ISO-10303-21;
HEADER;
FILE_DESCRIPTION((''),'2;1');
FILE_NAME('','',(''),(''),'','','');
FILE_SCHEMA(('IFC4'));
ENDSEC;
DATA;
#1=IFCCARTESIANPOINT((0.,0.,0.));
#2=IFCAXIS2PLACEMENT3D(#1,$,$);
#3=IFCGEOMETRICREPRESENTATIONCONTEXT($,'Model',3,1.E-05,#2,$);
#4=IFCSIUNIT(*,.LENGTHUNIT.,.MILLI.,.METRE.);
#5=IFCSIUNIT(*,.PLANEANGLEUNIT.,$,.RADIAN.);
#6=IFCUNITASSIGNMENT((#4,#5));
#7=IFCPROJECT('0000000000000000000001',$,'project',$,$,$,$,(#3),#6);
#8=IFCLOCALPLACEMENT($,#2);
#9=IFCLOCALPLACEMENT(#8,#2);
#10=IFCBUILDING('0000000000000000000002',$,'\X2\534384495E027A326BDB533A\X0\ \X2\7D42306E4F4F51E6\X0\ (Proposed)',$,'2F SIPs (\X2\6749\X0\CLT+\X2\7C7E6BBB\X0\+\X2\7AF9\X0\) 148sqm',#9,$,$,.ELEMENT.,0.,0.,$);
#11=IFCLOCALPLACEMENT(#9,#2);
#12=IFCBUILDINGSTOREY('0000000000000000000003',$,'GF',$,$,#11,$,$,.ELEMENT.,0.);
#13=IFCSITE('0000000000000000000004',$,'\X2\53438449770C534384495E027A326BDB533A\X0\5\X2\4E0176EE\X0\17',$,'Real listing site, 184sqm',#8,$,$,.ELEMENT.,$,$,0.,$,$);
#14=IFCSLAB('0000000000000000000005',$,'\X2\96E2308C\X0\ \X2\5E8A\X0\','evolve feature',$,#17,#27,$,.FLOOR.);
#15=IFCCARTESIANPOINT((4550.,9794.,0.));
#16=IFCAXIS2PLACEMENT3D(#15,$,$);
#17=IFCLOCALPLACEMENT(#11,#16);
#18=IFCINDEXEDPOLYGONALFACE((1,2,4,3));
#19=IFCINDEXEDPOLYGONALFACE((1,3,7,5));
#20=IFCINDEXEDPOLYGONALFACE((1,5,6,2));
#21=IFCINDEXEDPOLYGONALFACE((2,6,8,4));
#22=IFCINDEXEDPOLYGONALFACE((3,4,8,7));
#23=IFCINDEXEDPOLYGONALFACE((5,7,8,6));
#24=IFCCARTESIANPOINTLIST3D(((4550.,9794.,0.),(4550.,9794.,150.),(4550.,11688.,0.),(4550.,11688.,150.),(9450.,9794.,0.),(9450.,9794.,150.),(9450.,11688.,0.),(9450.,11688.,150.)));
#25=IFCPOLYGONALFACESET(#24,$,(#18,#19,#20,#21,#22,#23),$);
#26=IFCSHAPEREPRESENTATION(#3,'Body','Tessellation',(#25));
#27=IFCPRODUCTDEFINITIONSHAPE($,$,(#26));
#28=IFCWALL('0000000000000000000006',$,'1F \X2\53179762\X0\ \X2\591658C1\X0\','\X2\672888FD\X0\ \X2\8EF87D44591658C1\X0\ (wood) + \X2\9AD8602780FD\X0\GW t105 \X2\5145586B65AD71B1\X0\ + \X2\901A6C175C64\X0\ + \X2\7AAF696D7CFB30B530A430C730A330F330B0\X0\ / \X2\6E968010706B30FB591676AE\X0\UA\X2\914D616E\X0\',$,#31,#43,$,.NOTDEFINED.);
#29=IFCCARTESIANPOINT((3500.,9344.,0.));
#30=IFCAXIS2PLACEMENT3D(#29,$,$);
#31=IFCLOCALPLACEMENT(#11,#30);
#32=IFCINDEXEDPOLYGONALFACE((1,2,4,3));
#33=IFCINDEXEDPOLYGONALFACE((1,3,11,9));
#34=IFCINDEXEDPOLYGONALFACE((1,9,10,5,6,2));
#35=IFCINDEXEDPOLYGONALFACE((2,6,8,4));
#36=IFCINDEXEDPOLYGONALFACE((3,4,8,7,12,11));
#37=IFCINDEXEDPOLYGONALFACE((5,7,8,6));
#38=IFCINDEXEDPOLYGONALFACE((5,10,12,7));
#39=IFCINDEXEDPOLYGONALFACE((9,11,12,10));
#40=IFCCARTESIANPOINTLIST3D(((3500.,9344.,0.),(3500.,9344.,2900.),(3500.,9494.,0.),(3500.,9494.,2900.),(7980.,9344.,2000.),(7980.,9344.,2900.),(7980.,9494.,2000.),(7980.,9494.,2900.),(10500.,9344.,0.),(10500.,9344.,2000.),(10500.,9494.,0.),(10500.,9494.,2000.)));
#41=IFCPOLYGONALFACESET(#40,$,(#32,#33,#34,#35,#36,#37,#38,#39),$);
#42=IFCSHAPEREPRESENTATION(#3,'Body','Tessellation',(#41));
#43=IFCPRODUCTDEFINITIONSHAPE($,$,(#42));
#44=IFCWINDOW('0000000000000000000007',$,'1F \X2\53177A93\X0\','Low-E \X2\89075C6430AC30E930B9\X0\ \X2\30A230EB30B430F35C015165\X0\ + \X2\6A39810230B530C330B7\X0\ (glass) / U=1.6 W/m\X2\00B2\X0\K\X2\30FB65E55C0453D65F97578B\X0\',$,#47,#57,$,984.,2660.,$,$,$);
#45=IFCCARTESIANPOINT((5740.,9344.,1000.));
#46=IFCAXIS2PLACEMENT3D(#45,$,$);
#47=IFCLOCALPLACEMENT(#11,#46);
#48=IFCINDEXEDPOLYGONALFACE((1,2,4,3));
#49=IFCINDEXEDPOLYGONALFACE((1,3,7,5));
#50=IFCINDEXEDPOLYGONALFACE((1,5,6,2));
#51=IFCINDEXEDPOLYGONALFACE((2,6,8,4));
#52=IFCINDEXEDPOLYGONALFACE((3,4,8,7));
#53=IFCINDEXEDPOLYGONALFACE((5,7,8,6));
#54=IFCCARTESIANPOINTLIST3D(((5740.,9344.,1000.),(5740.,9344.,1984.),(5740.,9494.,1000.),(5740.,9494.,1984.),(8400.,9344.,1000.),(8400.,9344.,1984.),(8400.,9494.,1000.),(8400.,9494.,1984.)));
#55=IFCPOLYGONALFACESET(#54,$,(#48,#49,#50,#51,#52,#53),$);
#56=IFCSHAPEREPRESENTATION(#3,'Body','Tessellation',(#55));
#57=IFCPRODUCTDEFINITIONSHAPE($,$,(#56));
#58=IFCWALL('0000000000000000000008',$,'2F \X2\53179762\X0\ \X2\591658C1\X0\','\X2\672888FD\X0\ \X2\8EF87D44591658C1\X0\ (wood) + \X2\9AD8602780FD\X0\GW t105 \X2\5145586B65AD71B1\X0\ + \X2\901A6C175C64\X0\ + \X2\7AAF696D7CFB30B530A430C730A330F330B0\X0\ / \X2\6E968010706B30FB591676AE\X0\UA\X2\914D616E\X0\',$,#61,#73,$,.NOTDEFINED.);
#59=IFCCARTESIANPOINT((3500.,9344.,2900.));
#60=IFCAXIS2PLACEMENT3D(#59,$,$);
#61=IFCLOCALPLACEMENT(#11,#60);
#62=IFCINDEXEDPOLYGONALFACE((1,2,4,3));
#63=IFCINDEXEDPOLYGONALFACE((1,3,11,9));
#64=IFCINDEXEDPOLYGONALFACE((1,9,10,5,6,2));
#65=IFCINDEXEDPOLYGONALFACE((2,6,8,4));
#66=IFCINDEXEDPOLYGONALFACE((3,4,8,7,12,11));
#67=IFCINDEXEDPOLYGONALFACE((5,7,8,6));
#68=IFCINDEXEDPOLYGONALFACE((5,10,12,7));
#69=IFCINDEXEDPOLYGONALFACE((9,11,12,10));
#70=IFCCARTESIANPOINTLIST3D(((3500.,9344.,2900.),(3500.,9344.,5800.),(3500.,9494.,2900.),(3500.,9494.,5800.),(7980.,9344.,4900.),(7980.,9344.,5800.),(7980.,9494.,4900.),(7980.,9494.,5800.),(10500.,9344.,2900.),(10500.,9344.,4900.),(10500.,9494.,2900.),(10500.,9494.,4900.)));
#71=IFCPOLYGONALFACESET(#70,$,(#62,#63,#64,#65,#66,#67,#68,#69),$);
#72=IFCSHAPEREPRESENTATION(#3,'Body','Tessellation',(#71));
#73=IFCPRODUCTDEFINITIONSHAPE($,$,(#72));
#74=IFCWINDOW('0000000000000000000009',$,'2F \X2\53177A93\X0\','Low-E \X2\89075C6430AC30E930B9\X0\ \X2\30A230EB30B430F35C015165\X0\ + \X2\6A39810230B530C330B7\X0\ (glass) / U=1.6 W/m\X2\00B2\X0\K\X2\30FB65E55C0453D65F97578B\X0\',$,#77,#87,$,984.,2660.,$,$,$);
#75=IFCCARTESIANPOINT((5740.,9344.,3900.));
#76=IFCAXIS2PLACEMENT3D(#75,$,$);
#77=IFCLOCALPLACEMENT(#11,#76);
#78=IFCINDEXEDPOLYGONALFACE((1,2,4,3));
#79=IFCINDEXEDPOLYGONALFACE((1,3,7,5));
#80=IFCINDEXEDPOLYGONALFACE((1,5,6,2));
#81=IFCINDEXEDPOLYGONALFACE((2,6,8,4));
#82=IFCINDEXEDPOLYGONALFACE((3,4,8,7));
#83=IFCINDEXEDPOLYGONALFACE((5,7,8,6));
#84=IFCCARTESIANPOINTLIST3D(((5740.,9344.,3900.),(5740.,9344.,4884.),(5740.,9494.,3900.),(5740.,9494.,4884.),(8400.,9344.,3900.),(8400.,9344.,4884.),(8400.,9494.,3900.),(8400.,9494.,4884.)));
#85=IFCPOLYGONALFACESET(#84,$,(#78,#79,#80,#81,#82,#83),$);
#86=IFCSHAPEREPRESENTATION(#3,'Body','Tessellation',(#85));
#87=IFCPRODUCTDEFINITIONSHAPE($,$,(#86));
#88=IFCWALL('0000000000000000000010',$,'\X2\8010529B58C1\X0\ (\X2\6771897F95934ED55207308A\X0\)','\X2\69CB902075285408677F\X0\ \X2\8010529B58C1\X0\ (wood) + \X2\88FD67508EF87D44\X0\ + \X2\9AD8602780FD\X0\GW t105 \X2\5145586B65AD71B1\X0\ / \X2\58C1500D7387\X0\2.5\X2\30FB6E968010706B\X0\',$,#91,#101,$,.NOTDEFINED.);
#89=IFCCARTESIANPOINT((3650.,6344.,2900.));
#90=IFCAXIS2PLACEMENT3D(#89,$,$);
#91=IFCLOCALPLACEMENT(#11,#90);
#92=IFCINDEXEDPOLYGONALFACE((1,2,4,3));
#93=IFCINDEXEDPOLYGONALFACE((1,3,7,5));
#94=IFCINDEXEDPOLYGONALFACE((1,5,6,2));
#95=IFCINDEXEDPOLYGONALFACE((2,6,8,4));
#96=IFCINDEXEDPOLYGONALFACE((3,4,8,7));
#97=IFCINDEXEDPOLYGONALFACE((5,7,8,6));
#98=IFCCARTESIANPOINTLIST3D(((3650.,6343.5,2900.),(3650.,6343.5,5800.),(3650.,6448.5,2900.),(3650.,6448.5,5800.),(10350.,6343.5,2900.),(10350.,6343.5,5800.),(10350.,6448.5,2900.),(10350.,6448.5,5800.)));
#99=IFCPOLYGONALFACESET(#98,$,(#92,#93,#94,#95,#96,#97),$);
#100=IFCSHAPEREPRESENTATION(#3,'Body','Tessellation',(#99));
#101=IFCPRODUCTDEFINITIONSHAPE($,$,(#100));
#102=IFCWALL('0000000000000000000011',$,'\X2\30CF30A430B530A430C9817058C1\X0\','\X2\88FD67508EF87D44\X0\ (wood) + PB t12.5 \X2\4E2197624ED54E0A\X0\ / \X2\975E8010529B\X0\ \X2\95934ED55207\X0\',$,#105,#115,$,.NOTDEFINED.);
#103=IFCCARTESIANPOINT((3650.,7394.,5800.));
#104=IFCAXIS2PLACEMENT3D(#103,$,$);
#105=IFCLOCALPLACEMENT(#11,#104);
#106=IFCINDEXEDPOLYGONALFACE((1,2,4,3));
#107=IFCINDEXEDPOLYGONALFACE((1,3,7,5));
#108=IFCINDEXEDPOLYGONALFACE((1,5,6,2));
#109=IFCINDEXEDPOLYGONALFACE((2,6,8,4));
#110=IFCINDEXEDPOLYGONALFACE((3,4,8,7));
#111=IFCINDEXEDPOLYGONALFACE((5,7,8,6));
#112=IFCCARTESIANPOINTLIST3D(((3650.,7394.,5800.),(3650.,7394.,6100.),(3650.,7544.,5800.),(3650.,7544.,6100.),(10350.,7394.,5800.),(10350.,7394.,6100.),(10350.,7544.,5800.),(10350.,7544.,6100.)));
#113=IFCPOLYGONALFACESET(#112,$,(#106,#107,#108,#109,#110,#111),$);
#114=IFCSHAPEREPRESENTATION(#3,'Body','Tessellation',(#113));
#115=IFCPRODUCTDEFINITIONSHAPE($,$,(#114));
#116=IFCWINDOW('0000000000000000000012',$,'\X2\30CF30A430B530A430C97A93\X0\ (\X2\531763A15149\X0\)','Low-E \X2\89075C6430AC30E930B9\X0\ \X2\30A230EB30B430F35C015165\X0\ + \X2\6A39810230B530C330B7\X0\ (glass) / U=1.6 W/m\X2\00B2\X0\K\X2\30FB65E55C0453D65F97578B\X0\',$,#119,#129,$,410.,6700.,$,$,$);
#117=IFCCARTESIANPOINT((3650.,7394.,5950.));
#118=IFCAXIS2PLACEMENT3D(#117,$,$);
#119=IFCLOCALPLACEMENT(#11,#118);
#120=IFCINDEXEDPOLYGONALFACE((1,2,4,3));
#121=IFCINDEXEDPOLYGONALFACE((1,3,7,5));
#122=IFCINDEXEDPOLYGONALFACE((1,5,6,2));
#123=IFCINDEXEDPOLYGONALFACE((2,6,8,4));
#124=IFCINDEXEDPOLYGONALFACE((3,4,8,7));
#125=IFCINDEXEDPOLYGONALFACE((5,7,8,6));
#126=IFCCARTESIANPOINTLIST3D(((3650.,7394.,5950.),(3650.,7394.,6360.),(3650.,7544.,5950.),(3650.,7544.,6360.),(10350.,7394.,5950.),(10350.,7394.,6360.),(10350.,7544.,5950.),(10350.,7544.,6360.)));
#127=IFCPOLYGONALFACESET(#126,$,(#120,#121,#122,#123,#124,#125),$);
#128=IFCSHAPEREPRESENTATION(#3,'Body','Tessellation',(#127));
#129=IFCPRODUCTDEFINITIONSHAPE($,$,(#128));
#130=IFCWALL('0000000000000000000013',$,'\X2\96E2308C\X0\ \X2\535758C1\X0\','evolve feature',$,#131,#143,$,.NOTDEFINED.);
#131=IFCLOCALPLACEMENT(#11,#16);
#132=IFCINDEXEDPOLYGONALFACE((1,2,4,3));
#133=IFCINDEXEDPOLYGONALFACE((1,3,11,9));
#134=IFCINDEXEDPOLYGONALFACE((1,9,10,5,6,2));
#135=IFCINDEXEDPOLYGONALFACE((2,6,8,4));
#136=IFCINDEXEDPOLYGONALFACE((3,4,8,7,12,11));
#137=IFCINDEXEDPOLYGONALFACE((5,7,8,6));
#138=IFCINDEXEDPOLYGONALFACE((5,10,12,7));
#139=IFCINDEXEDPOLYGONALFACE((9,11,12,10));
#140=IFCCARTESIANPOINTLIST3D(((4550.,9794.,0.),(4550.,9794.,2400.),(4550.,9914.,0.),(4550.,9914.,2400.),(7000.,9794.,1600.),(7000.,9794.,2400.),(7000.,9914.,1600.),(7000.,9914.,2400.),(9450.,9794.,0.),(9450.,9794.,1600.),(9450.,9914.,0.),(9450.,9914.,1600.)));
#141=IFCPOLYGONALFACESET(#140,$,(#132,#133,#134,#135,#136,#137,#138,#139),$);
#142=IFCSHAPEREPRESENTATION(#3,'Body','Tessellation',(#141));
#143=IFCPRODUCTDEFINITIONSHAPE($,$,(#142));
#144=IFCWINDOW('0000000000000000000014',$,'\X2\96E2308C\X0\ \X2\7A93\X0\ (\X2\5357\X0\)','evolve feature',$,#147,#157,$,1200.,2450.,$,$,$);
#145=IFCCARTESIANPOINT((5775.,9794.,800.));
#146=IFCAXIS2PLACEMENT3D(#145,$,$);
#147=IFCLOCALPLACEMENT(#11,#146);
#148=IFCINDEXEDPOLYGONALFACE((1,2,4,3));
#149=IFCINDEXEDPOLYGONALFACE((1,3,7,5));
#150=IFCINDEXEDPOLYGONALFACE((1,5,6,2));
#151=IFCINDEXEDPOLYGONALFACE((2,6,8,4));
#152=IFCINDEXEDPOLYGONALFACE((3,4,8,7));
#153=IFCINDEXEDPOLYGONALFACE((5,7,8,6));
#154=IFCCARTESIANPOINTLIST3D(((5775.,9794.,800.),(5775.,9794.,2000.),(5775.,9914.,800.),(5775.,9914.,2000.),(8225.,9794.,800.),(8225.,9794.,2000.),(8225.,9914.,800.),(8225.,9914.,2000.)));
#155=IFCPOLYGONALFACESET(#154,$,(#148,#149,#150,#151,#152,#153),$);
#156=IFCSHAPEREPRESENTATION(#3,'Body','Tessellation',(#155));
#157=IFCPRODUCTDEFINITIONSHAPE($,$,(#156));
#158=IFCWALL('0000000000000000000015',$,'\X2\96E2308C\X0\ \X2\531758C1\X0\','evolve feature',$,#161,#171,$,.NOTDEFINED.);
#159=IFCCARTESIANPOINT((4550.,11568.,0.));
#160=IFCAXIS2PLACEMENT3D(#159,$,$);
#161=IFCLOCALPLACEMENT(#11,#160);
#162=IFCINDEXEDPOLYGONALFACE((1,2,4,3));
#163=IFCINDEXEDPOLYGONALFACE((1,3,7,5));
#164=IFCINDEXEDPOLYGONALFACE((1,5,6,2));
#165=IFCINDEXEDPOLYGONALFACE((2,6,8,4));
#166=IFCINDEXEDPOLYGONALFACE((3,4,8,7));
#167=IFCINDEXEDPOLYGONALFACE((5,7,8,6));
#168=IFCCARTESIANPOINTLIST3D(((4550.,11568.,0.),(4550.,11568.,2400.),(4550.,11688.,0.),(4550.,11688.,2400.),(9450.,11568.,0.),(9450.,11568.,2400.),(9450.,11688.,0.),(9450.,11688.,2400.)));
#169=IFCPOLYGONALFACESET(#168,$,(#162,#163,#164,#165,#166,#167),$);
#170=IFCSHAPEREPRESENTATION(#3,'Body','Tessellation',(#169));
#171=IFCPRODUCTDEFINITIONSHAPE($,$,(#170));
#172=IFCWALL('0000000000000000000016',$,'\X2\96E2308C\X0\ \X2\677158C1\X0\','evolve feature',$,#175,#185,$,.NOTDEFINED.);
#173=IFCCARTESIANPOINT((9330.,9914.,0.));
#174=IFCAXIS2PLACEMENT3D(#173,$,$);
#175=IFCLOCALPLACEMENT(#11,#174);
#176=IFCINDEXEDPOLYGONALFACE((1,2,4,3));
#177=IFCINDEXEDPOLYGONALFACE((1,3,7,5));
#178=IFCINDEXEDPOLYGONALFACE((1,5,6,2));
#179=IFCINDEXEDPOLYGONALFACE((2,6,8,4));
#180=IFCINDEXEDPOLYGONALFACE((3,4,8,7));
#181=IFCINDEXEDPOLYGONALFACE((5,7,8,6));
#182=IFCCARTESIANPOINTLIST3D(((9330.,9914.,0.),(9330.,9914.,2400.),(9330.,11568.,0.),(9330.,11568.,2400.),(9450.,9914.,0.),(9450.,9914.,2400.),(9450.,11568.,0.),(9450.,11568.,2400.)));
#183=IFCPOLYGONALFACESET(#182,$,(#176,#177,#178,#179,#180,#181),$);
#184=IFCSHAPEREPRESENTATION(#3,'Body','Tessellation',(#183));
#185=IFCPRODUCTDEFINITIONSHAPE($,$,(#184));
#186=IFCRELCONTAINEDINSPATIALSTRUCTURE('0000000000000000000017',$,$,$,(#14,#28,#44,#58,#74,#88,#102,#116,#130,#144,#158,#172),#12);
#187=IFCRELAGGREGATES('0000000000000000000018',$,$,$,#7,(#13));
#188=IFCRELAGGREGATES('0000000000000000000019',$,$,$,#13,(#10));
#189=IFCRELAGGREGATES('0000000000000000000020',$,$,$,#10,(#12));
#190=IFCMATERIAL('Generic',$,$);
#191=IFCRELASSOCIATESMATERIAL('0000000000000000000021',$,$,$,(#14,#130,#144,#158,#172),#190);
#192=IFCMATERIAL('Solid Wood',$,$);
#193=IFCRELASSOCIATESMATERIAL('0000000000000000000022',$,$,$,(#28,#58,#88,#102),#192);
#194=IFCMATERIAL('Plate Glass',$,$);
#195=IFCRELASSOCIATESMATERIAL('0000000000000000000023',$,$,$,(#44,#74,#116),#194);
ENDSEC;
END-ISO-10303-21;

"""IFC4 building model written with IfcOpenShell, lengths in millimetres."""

from ifc_helpers import new_model, si_unit, frame, frame_2d, origin, place, context, project, spatial, rectangle, extrude, material, element, fill, save


model = new_model("IFC4")

# Units and contexts
model_context = context("Model", 3, precision=1e-05, world=origin())
ifc_project = project(units=[si_unit("LENGTHUNIT", "METRE", prefix="MILLI"), si_unit("PLANEANGLEUNIT", "RADIAN")], contexts=[model_context])

# Site, building, storey
site_placement = place(None, origin())
site = spatial("IfcSite", under=ifc_project, at=site_placement, Name="千葉県千葉市稲毛区5丁目17", ObjectType="Real listing site, 184sqm", CompositionType="ELEMENT", RefElevation=0.0)
building_placement = place(site_placement, origin())
building = spatial("IfcBuilding", under=site, at=building_placement, Name="千葉市稲毛区 終の住処 (Proposed)", ObjectType="2F SIPs (杉CLT+籾殻+竹) 148sqm", CompositionType="ELEMENT", ElevationOfRefHeight=0.0, ElevationOfTerrain=0.0)
storey_placement = place(building_placement, origin())
storey = spatial("IfcBuildingStorey", under=building, at=storey_placement, Name="GF", CompositionType="ELEMENT", Elevation=0.0)

# Slab
ifc_material_1 = material(Name="Generic")
slab_placement = place(storey_placement, frame((4550.0, 9794.0, 0.0)))
element("IfcSlab", 1, at=slab_placement, inside=storey, material=ifc_material_1, Name="離れ 床", Description="evolve feature", PredefinedType="FLOOR", context=model_context, shape_type="SweptSolid", body=[
    extrude(rectangle(XDim=4900.0, YDim=1894.0, at=frame_2d((2450.0, 947.0))), frame((4550.0, 9794.0, 0.0)), (0.0, 0.0, 1.0), 150.0),
])

# Wall, opening, window
ifc_material_2 = material(Name="Solid Wood")
wall_1_placement = place(storey_placement, frame((3500.0, 9344.0, 0.0)))
wall_1 = element("IfcWall", 2, at=wall_1_placement, inside=storey, material=ifc_material_2, Name="1F 北面 外壁", Description="木製 軸組外壁 (wood) + 高性能GW t105 充填断熱 + 通気層 + 窯業系サイディング / 準耐火・外皮UA配慮", PredefinedType="NOTDEFINED", context=model_context, shape_type="SweptSolid", body=[
    extrude(rectangle(XDim=7000.0, YDim=150.0, at=frame_2d((3500.0, 75.0))), frame((3500.0, 9344.0, 0.0)), (0.0, 0.0, 1.0), 2900.0),
])
opening_1_placement = place(storey_placement, frame((5740.0, 9344.0, 1000.0)))
opening_1 = element("IfcOpeningElement", 3, at=opening_1_placement, cuts=wall_1, PredefinedType="NOTDEFINED", context=model_context, shape_type="SweptSolid", body=[
    extrude(rectangle(XDim=2660.0, YDim=150.0, at=frame_2d((1330.0, 75.0))), frame((5740.0, 9344.0, 1000.0)), (0.0, 0.0, 1.0), 984.0),
])
ifc_material_3 = material(Name="Plate Glass")
window_1_placement = place(storey_placement, frame((5740.0, 9344.0, 1000.0)))
window_1 = element("IfcWindow", 4, at=window_1_placement, inside=storey, material=ifc_material_3, Name="1F 北窓", Description="Low-E 複層ガラス アルゴン封入 + 樹脂サッシ (glass) / U=1.6 W/m²K・日射取得型", OverallHeight=984.0, OverallWidth=2660.0, context=model_context, shape_type="SweptSolid", body=[
    extrude(rectangle(XDim=2660.0, YDim=150.0, at=frame_2d((1330.0, 75.0))), frame((5740.0, 9344.0, 1000.0)), (0.0, 0.0, 1.0), 984.0),
])
fill(opening_1, window_1)

# Wall, opening, window
wall_2_placement = place(storey_placement, frame((3500.0, 9344.0, 2900.0)))
wall_2 = element("IfcWall", 5, at=wall_2_placement, inside=storey, material=ifc_material_2, Name="2F 北面 外壁", Description="木製 軸組外壁 (wood) + 高性能GW t105 充填断熱 + 通気層 + 窯業系サイディング / 準耐火・外皮UA配慮", PredefinedType="NOTDEFINED", context=model_context, shape_type="SweptSolid", body=[
    extrude(rectangle(XDim=7000.0, YDim=150.0, at=frame_2d((3500.0, 75.0))), frame((3500.0, 9344.0, 2900.0)), (0.0, 0.0, 1.0), 2900.0),
])
opening_2_placement = place(storey_placement, frame((5740.0, 9344.0, 3900.0)))
opening_2 = element("IfcOpeningElement", 6, at=opening_2_placement, cuts=wall_2, PredefinedType="NOTDEFINED", context=model_context, shape_type="SweptSolid", body=[
    extrude(rectangle(XDim=2660.0, YDim=150.0, at=frame_2d((1330.0, 75.0))), frame((5740.0, 9344.0, 3900.0)), (0.0, 0.0, 1.0), 984.0),
])
window_2_placement = place(storey_placement, frame((5740.0, 9344.0, 3900.0)))
window_2 = element("IfcWindow", 7, at=window_2_placement, inside=storey, material=ifc_material_3, Name="2F 北窓", Description="Low-E 複層ガラス アルゴン封入 + 樹脂サッシ (glass) / U=1.6 W/m²K・日射取得型", OverallHeight=984.0, OverallWidth=2660.0, context=model_context, shape_type="SweptSolid", body=[
    extrude(rectangle(XDim=2660.0, YDim=150.0, at=frame_2d((1330.0, 75.0))), frame((5740.0, 9344.0, 3900.0)), (0.0, 0.0, 1.0), 984.0),
])
fill(opening_2, window_2)

# Wall
wall_3_placement = place(storey_placement, frame((3650.0, 6344.0, 2900.0)))
element("IfcWall", 8, at=wall_3_placement, inside=storey, material=ifc_material_2, Name="耐力壁 (東西間仕切り)", Description="構造用合板 耐力壁 (wood) + 製材軸組 + 高性能GW t105 充填断熱 / 壁倍率2.5・準耐火", PredefinedType="NOTDEFINED", context=model_context, shape_type="SweptSolid", body=[
    extrude(rectangle(XDim=6700.0, YDim=105.0, at=frame_2d((3350.0, 52.0))), frame((3650.0, 6344.0, 2900.0)), (0.0, 0.0, 1.0), 2900.0),
])

# Walls, openings, windows
wall_4_placement = place(storey_placement, frame((3650.0, 7394.0, 5800.0)))
wall_4 = element("IfcWall", 9, at=wall_4_placement, inside=storey, material=ifc_material_2, Name="ハイサイド腰壁", Description="製材軸組 (wood) + PB t12.5 両面仕上 / 非耐力 間仕切", PredefinedType="NOTDEFINED", context=model_context, shape_type="SweptSolid", body=[
    extrude(rectangle(XDim=6700.0, YDim=150.0, at=frame_2d((3350.0, 75.0))), frame((3650.0, 7394.0, 5800.0)), (0.0, 0.0, 1.0), 700.0),
])
opening_3_placement = place(storey_placement, frame((3650.0, 7394.0, 5950.0)))
opening_3 = element("IfcOpeningElement", 10, at=opening_3_placement, cuts=wall_4, PredefinedType="NOTDEFINED", context=model_context, shape_type="SweptSolid", body=[
    extrude(rectangle(XDim=6700.0, YDim=150.0, at=frame_2d((3350.0, 75.0))), frame((3650.0, 7394.0, 5950.0)), (0.0, 0.0, 1.0), 410.0),
])
window_3_placement = place(storey_placement, frame((3650.0, 7394.0, 5950.0)))
window_3 = element("IfcWindow", 11, at=window_3_placement, inside=storey, material=ifc_material_3, Name="ハイサイド窓 (北採光)", Description="Low-E 複層ガラス アルゴン封入 + 樹脂サッシ (glass) / U=1.6 W/m²K・日射取得型", OverallHeight=410.0, OverallWidth=6700.0, context=model_context, shape_type="SweptSolid", body=[
    extrude(rectangle(XDim=6700.0, YDim=150.0, at=frame_2d((3350.0, 75.0))), frame((3650.0, 7394.0, 5950.0)), (0.0, 0.0, 1.0), 410.0),
])
fill(opening_3, window_3)
wall_5_placement = place(storey_placement, frame((4550.0, 9794.0, 0.0)))
wall_5 = element("IfcWall", 12, at=wall_5_placement, inside=storey, material=ifc_material_1, Name="離れ 南壁", Description="evolve feature", PredefinedType="NOTDEFINED", context=model_context, shape_type="SweptSolid", body=[
    extrude(rectangle(XDim=4900.0, YDim=120.0, at=frame_2d((2450.0, 60.0))), frame((4550.0, 9794.0, 0.0)), (0.0, 0.0, 1.0), 2400.0),
])
opening_4_placement = place(storey_placement, frame((5775.0, 9794.0, 800.0)))
opening_4 = element("IfcOpeningElement", 13, at=opening_4_placement, cuts=wall_5, PredefinedType="NOTDEFINED", context=model_context, shape_type="SweptSolid", body=[
    extrude(rectangle(XDim=2450.0, YDim=120.0, at=frame_2d((1225.0, 60.0))), frame((5775.0, 9794.0, 800.0)), (0.0, 0.0, 1.0), 1200.0),
])
window_4_placement = place(storey_placement, frame((5775.0, 9794.0, 800.0)))
window_4 = element("IfcWindow", 14, at=window_4_placement, inside=storey, material=ifc_material_1, Name="離れ 窓 (南)", Description="evolve feature", OverallHeight=1200.0, OverallWidth=2450.0, context=model_context, shape_type="SweptSolid", body=[
    extrude(rectangle(XDim=2450.0, YDim=120.0, at=frame_2d((1225.0, 60.0))), frame((5775.0, 9794.0, 800.0)), (0.0, 0.0, 1.0), 1200.0),
])
fill(opening_4, window_4)

# Walls
wall_6_placement = place(storey_placement, frame((4550.0, 11568.0, 0.0)))
element("IfcWall", 15, at=wall_6_placement, inside=storey, material=ifc_material_1, Name="離れ 北壁", Description="evolve feature", PredefinedType="NOTDEFINED", context=model_context, shape_type="SweptSolid", body=[
    extrude(rectangle(XDim=4900.0, YDim=120.0, at=frame_2d((2450.0, 60.0))), frame((4550.0, 11568.0, 0.0)), (0.0, 0.0, 1.0), 2400.0),
])
wall_7_placement = place(storey_placement, frame((9330.0, 9914.0, 0.0)))
element("IfcWall", 16, at=wall_7_placement, inside=storey, material=ifc_material_1, Name="離れ 東壁", Description="evolve feature", PredefinedType="NOTDEFINED", context=model_context, shape_type="SweptSolid", body=[
    extrude(rectangle(XDim=120.0, YDim=1654.0, at=frame_2d((60.0, 827.0))), frame((9330.0, 9914.0, 0.0)), (0.0, 0.0, 1.0), 2400.0),
])

save(model, "model.ifc")
